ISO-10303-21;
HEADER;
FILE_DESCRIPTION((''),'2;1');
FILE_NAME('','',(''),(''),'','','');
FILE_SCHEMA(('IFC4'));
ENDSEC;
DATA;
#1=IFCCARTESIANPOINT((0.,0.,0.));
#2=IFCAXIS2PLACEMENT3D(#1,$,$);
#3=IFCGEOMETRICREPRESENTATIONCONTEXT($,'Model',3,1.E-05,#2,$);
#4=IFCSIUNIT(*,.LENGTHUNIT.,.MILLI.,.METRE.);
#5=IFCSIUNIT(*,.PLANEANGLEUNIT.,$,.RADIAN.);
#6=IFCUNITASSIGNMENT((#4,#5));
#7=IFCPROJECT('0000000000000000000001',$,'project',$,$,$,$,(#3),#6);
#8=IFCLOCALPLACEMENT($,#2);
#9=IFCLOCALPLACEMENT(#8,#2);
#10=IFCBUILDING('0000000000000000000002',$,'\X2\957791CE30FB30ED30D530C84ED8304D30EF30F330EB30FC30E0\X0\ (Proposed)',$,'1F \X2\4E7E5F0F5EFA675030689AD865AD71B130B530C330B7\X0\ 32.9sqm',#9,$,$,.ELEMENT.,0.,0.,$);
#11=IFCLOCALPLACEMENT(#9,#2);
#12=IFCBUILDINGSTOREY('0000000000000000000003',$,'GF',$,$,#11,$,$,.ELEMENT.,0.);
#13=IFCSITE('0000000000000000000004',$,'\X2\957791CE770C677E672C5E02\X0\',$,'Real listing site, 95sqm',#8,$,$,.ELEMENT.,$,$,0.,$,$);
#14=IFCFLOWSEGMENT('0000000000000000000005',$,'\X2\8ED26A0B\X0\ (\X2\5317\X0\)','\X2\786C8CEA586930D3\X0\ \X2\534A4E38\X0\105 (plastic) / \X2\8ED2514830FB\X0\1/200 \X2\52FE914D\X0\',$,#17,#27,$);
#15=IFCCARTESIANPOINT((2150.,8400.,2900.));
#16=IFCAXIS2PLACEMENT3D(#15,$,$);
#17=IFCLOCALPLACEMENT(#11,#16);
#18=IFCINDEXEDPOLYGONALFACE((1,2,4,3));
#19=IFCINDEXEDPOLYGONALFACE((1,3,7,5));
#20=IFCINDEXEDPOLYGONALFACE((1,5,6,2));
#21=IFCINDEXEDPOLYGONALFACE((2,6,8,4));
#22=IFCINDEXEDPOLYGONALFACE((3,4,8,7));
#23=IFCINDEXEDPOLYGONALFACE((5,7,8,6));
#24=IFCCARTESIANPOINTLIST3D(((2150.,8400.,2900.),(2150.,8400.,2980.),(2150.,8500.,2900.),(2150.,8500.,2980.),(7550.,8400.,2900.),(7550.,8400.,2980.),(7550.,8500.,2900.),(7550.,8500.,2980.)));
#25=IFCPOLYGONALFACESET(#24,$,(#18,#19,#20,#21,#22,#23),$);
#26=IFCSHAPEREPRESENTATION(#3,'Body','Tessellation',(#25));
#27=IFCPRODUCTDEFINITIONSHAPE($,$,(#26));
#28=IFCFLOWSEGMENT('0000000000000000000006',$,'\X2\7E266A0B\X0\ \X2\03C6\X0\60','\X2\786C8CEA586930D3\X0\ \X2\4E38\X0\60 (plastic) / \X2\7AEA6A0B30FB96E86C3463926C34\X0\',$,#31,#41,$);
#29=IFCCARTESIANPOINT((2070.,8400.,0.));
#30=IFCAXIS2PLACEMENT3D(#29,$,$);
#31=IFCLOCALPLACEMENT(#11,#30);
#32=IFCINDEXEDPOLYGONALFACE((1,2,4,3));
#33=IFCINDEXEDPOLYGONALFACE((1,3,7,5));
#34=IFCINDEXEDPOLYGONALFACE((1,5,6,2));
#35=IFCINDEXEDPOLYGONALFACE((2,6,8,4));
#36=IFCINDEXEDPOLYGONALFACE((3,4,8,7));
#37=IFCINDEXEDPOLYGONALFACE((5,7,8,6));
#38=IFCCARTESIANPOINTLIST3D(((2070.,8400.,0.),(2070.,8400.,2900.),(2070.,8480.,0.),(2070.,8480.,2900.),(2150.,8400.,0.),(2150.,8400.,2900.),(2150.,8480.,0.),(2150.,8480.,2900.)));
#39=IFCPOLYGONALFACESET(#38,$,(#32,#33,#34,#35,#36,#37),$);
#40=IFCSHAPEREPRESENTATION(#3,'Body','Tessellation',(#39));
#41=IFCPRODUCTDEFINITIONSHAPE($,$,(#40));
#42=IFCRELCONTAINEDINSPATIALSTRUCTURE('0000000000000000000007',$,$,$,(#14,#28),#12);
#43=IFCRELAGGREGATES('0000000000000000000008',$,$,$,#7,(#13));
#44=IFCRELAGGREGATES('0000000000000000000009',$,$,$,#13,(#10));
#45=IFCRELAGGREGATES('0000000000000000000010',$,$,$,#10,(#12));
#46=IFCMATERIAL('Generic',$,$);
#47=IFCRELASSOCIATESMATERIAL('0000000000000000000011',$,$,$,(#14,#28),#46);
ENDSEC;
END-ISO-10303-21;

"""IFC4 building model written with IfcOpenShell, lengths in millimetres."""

from ifc_helpers import new_model, si_unit, frame, frame_2d, origin, place, context, project, spatial, rectangle, extrude, material, element, save


model = new_model("IFC4")

# Units and contexts
model_context = context("Model", 3, precision=1e-05, world=origin())
ifc_project = project(units=[si_unit("LENGTHUNIT", "METRE", prefix="MILLI"), si_unit("PLANEANGLEUNIT", "RADIAN")], contexts=[model_context])

# Site, building, storey
site_placement = place(None, origin())
site = spatial("IfcSite", under=ifc_project, at=site_placement, Name="長野県松本市", ObjectType="Real listing site, 95sqm", CompositionType="ELEMENT", RefElevation=0.0)
building_placement = place(site_placement, origin())
building = spatial("IfcBuilding", under=site, at=building_placement, Name="長野・ロフト付きワンルーム (Proposed)", ObjectType="1F 乾式建材と高断熱サッシ 32.9sqm", CompositionType="ELEMENT", ElevationOfRefHeight=0.0, ElevationOfTerrain=0.0)
storey_placement = place(building_placement, origin())
storey = spatial("IfcBuildingStorey", under=building, at=storey_placement, Name="GF", CompositionType="ELEMENT", Elevation=0.0)

# Shared definitions
ifc_material_1 = material(Name="Generic")

# Flow segments
flow_segment_1_placement = place(storey_placement, frame((2150.0, 8400.0, 2900.0)))
element("IfcFlowSegment", 1, at=flow_segment_1_placement, inside=storey, material=ifc_material_1, Name="軒樋 (北)", Description="硬質塩ビ 半丸105 (plastic) / 軒先・1/200 勾配", context=model_context, shape_type="SweptSolid", body=[
    extrude(rectangle(XDim=5400.0, YDim=100.0, at=frame_2d((2700.0, 50.0))), frame((2150.0, 8400.0, 2900.0)), (0.0, 0.0, 1.0), 80.0),
])
flow_segment_2_placement = place(storey_placement, frame((2070.0, 8400.0, 0.0)))
element("IfcFlowSegment", 2, at=flow_segment_2_placement, inside=storey, material=ifc_material_1, Name="縦樋 φ60", Description="硬質塩ビ 丸60 (plastic) / 竪樋・雨水排水", context=model_context, shape_type="SweptSolid", body=[
    extrude(rectangle(XDim=80.0, YDim=80.0, at=frame_2d((40.0, 40.0))), frame((2070.0, 8400.0, 0.0)), (0.0, 0.0, 1.0), 2900.0),
])

save(model, "model.ifc")
